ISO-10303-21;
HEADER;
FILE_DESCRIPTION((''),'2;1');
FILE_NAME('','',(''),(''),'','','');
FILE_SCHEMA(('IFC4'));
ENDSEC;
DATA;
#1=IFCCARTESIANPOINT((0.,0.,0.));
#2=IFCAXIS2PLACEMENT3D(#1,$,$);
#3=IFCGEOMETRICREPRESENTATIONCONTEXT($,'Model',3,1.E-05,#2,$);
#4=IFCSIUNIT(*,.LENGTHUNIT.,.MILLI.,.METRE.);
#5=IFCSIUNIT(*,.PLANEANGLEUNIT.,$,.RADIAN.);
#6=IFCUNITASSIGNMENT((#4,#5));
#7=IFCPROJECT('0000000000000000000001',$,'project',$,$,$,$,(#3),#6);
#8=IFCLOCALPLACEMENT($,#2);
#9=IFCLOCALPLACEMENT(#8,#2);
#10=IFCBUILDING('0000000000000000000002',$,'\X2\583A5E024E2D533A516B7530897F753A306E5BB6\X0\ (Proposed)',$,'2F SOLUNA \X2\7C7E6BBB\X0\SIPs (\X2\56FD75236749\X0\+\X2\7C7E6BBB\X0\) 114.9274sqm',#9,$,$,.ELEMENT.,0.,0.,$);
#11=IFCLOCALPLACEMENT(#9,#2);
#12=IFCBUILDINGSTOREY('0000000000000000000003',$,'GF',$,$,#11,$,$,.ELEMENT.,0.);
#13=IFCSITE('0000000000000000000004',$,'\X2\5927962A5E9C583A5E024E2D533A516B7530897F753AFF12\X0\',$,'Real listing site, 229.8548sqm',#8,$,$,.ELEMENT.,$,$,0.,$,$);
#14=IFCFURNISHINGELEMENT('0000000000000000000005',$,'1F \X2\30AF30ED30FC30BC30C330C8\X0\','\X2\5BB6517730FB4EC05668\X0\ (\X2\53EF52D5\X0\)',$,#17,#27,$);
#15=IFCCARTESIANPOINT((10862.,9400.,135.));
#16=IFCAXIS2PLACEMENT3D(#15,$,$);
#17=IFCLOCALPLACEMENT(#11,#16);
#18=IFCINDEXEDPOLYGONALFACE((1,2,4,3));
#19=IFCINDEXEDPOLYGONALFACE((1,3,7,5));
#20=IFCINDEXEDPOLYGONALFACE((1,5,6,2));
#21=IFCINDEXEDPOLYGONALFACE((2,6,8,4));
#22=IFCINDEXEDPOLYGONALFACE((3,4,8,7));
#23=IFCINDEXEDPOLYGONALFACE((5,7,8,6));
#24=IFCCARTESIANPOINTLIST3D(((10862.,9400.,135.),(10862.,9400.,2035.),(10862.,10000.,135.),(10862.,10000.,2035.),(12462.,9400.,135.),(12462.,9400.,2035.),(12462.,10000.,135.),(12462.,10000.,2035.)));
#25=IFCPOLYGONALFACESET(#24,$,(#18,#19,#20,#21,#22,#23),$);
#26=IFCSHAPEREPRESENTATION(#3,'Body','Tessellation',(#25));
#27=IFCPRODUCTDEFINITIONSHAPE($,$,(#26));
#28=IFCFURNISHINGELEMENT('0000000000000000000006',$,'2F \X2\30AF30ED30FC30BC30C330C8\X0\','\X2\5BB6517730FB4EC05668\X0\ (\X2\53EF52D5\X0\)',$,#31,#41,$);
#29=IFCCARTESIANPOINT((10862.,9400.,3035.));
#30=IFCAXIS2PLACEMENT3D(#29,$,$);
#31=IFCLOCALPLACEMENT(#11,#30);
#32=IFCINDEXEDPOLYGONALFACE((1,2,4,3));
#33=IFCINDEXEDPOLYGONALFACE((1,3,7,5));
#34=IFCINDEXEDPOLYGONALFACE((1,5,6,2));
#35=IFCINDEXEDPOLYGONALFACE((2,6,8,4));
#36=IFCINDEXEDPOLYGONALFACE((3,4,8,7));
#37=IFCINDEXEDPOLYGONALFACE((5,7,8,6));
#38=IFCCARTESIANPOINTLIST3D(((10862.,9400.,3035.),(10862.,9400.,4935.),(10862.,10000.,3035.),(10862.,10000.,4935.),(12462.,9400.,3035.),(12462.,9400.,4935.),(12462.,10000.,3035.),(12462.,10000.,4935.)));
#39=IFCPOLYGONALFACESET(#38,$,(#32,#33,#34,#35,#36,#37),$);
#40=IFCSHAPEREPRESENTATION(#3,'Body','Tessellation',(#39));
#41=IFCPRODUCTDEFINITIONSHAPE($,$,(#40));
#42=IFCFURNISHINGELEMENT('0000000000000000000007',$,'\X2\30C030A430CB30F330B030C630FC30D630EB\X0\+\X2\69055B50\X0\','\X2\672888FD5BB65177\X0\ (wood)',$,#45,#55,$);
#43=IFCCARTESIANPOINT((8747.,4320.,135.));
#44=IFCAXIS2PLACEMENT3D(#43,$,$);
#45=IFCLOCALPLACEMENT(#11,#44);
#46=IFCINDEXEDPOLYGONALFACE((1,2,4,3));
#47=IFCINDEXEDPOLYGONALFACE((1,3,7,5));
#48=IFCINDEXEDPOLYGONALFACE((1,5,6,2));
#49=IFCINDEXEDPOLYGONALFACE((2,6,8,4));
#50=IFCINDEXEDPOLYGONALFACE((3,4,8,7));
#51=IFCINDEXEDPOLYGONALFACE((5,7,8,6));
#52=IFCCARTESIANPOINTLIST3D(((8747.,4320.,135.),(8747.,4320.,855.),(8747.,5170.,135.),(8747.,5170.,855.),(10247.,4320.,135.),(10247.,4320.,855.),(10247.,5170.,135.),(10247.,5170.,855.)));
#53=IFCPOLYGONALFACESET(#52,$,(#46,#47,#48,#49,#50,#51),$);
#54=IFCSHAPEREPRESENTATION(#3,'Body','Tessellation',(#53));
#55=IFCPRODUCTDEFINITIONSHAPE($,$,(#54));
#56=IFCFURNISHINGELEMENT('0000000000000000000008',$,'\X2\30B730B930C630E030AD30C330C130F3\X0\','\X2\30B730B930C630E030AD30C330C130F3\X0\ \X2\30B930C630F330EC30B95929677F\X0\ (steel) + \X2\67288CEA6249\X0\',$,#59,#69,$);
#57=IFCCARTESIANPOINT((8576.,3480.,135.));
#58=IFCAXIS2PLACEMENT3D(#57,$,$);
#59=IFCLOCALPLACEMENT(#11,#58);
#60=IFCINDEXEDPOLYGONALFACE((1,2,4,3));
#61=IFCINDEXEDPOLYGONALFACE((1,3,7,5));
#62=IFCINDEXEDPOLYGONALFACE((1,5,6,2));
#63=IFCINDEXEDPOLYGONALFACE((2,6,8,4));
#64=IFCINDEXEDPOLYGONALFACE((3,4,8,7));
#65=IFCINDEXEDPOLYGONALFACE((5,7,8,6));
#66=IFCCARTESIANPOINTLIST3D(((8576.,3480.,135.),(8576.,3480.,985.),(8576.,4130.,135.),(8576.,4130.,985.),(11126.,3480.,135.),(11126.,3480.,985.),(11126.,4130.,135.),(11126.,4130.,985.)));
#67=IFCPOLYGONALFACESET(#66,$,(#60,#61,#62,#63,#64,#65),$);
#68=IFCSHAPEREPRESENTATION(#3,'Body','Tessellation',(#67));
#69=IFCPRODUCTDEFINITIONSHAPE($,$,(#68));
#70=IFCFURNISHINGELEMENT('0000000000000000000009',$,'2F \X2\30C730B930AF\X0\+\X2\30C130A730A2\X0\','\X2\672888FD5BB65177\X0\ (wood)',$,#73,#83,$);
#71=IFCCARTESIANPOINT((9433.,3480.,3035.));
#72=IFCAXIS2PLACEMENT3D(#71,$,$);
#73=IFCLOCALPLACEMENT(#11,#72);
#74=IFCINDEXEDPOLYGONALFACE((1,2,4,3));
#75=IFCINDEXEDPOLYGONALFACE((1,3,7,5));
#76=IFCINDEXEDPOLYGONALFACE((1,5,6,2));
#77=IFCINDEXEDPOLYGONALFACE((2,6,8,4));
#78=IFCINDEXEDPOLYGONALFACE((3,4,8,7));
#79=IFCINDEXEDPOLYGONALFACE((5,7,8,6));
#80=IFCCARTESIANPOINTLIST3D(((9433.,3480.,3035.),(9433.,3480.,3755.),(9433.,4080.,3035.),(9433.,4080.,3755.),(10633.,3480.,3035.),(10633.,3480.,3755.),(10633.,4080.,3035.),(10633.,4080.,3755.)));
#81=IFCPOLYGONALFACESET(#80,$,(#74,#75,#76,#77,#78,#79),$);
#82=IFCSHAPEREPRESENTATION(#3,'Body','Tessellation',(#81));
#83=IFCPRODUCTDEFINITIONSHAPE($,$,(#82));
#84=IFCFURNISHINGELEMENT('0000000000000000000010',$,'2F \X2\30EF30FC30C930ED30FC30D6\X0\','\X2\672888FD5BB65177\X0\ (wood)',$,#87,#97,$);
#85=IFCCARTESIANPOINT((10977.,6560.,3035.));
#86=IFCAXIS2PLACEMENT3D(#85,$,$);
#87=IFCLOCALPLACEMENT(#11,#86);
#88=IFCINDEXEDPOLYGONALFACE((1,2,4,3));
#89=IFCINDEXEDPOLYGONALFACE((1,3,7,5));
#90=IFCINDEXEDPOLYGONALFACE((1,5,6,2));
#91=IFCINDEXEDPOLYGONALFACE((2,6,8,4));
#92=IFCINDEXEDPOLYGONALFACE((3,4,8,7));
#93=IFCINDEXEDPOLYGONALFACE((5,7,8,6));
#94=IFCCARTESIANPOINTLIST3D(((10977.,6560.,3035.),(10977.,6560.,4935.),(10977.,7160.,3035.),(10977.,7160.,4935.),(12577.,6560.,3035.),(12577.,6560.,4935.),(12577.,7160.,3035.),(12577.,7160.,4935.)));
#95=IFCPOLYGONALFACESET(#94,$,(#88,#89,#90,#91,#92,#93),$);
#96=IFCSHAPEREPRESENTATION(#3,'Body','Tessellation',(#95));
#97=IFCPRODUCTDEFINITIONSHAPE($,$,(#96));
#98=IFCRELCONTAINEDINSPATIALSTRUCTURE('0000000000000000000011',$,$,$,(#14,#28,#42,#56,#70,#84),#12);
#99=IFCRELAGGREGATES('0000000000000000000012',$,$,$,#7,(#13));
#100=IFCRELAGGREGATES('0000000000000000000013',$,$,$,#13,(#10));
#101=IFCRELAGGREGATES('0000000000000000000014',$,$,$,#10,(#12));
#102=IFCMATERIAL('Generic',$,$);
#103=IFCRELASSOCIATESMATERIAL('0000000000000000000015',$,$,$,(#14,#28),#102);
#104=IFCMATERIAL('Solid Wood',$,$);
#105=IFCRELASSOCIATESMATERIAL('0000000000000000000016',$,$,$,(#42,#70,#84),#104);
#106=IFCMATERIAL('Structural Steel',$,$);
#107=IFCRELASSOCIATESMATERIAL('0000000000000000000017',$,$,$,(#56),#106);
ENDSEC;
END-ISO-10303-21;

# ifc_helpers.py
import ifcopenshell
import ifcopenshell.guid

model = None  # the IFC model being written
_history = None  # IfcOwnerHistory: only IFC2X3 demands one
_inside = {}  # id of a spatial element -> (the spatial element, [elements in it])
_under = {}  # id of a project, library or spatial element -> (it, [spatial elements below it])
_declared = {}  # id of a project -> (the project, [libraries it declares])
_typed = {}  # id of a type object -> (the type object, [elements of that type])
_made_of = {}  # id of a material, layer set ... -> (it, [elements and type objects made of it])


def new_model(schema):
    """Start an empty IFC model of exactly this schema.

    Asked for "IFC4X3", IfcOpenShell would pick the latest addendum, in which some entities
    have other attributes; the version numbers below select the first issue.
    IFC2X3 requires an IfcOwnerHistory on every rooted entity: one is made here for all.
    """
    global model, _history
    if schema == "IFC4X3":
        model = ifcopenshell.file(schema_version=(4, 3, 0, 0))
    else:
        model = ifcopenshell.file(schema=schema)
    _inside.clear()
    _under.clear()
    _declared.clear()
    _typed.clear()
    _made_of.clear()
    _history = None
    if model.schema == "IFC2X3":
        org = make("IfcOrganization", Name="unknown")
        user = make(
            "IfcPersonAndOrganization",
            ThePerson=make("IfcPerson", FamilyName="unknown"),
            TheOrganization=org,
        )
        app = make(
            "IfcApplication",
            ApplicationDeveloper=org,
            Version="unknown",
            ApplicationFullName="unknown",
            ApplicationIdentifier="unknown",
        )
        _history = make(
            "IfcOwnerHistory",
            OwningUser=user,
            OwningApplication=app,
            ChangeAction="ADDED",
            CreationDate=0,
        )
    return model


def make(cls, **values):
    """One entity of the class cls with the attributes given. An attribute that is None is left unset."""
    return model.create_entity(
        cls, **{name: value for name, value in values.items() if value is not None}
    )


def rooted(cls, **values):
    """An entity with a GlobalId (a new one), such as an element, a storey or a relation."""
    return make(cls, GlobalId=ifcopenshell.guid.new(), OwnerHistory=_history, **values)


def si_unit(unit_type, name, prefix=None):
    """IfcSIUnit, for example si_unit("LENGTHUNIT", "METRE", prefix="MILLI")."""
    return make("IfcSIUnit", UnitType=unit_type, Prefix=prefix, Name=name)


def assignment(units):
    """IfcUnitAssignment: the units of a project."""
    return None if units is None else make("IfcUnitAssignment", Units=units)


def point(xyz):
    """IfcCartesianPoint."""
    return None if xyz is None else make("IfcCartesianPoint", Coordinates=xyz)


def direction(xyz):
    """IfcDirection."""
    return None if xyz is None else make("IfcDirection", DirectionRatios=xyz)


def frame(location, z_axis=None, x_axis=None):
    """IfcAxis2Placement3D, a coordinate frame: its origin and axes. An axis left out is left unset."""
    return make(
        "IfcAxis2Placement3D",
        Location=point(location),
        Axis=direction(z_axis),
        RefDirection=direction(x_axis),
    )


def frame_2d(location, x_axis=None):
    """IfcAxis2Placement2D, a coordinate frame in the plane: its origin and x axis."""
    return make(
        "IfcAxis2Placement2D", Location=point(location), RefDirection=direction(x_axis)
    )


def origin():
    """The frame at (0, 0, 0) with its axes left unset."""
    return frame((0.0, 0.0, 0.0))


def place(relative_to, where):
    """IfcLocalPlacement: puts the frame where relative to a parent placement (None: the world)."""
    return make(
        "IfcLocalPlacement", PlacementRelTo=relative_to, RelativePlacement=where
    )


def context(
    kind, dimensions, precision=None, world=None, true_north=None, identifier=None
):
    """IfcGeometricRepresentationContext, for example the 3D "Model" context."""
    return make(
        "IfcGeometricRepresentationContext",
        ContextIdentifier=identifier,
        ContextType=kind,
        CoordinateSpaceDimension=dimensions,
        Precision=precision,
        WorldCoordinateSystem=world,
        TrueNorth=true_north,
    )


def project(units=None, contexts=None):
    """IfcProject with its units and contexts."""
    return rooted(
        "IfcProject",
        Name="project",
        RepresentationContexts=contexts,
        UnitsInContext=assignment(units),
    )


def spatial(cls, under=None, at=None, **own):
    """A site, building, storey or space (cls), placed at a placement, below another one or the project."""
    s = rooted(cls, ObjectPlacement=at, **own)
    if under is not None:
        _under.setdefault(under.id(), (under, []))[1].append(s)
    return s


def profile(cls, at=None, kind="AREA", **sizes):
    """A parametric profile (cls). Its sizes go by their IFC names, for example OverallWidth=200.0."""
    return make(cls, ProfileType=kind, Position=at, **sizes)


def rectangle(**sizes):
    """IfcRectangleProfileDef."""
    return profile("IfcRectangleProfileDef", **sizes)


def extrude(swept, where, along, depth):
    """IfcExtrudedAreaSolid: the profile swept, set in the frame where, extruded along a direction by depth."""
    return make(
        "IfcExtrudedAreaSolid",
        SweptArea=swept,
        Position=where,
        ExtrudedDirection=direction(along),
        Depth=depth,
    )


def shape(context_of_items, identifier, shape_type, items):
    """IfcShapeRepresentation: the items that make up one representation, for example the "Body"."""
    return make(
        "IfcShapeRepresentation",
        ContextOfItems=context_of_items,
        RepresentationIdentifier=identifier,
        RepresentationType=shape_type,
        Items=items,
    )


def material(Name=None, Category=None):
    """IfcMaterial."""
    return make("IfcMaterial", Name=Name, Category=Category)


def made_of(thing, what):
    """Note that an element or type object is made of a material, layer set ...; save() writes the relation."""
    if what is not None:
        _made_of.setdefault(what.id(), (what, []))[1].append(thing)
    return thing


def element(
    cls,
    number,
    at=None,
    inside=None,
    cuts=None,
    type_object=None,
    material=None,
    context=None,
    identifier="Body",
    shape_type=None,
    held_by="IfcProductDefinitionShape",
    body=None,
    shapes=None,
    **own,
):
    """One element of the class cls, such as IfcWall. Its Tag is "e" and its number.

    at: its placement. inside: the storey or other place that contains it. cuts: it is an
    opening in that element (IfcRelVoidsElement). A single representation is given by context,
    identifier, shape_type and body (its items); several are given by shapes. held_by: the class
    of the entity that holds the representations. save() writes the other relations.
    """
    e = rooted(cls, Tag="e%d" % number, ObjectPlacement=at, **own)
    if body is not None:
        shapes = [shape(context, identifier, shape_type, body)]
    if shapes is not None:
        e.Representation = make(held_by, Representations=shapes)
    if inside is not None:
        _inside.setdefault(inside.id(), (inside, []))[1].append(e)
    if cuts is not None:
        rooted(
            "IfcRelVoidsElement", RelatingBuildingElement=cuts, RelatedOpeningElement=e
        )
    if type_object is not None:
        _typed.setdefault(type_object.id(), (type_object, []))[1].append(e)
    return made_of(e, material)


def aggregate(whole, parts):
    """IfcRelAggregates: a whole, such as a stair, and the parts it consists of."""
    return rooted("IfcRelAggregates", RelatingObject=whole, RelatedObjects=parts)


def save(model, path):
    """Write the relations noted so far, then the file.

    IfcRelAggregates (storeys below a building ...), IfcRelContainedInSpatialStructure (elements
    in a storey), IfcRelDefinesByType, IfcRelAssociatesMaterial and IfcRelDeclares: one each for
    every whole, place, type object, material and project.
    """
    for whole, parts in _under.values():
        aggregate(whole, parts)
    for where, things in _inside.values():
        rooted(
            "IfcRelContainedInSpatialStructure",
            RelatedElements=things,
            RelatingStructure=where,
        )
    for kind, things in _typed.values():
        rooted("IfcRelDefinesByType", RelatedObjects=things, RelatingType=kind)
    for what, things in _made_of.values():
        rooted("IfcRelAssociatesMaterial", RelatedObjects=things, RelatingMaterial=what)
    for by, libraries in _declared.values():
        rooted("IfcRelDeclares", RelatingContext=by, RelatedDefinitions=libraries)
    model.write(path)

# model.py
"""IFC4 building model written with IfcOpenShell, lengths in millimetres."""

from ifc_helpers import new_model, si_unit, frame, frame_2d, origin, place, context, project, spatial, rectangle, extrude, material, element, save


model = new_model("IFC4")

# Units and contexts
model_context = context("Model", 3, precision=1e-05, world=origin())
ifc_project = project(units=[si_unit("LENGTHUNIT", "METRE", prefix="MILLI"), si_unit("PLANEANGLEUNIT", "RADIAN")], contexts=[model_context])

# Site, building, storey
site_placement = place(None, origin())
site = spatial("IfcSite", under=ifc_project, at=site_placement, Name="大阪府堺市中区八田西町２", ObjectType="Real listing site, 229.8548sqm", CompositionType="ELEMENT", RefElevation=0.0)
building_placement = place(site_placement, origin())
building = spatial("IfcBuilding", under=site, at=building_placement, Name="堺市中区八田西町の家 (Proposed)", ObjectType="2F SOLUNA 籾殻SIPs (国産杉+籾殻) 114.9274sqm", CompositionType="ELEMENT", ElevationOfRefHeight=0.0, ElevationOfTerrain=0.0)
storey_placement = place(building_placement, origin())
storey = spatial("IfcBuildingStorey", under=building, at=storey_placement, Name="GF", CompositionType="ELEMENT", Elevation=0.0)

# Shared definitions
ifc_material_1 = material(Name="Solid Wood")

# Shared definitions
ifc_material_2 = material(Name="Generic")

# Furnishing elements
furnishing_1_placement = place(storey_placement, frame((10862.0, 9400.0, 135.0)))
element("IfcFurnishingElement", 1, at=furnishing_1_placement, inside=storey, material=ifc_material_2, Name="1F クローゼット", Description="家具・什器 (可動)", context=model_context, shape_type="SweptSolid", body=[
    extrude(rectangle(XDim=1600.0, YDim=600.0, at=frame_2d((800.0, 300.0))), frame((10862.0, 9400.0, 135.0)), (0.0, 0.0, 1.0), 1900.0),
])
furnishing_2_placement = place(storey_placement, frame((10862.0, 9400.0, 3035.0)))
element("IfcFurnishingElement", 2, at=furnishing_2_placement, inside=storey, material=ifc_material_2, Name="2F クローゼット", Description="家具・什器 (可動)", context=model_context, shape_type="SweptSolid", body=[
    extrude(rectangle(XDim=1600.0, YDim=600.0, at=frame_2d((800.0, 300.0))), frame((10862.0, 9400.0, 3035.0)), (0.0, 0.0, 1.0), 1900.0),
])
furnishing_3_placement = place(storey_placement, frame((8747.0, 4320.0, 135.0)))
element("IfcFurnishingElement", 3, at=furnishing_3_placement, inside=storey, material=ifc_material_1, Name="ダイニングテーブル+椅子", Description="木製家具 (wood)", context=model_context, shape_type="SweptSolid", body=[
    extrude(rectangle(XDim=1500.0, YDim=850.0, at=frame_2d((750.0, 425.0))), frame((8747.0, 4320.0, 135.0)), (0.0, 0.0, 1.0), 720.0),
])
ifc_material_3 = material(Name="Structural Steel")
furnishing_4_placement = place(storey_placement, frame((8576.0, 3480.0, 135.0)))
element("IfcFurnishingElement", 4, at=furnishing_4_placement, inside=storey, material=ifc_material_3, Name="システムキッチン", Description="システムキッチン ステンレス天板 (steel) + 木質扉", context=model_context, shape_type="SweptSolid", body=[
    extrude(rectangle(XDim=2550.0, YDim=650.0, at=frame_2d((1275.0, 325.0))), frame((8576.0, 3480.0, 135.0)), (0.0, 0.0, 1.0), 850.0),
])
furnishing_5_placement = place(storey_placement, frame((9433.0, 3480.0, 3035.0)))
element("IfcFurnishingElement", 5, at=furnishing_5_placement, inside=storey, material=ifc_material_1, Name="2F デスク+チェア", Description="木製家具 (wood)", context=model_context, shape_type="SweptSolid", body=[
    extrude(rectangle(XDim=1200.0, YDim=600.0, at=frame_2d((600.0, 300.0))), frame((9433.0, 3480.0, 3035.0)), (0.0, 0.0, 1.0), 720.0),
])
furnishing_6_placement = place(storey_placement, frame((10977.0, 6560.0, 3035.0)))
element("IfcFurnishingElement", 6, at=furnishing_6_placement, inside=storey, material=ifc_material_1, Name="2F ワードローブ", Description="木製家具 (wood)", context=model_context, shape_type="SweptSolid", body=[
    extrude(rectangle(XDim=1600.0, YDim=600.0, at=frame_2d((800.0, 300.0))), frame((10977.0, 6560.0, 3035.0)), (0.0, 0.0, 1.0), 1900.0),
])

save(model, "model.ifc")
